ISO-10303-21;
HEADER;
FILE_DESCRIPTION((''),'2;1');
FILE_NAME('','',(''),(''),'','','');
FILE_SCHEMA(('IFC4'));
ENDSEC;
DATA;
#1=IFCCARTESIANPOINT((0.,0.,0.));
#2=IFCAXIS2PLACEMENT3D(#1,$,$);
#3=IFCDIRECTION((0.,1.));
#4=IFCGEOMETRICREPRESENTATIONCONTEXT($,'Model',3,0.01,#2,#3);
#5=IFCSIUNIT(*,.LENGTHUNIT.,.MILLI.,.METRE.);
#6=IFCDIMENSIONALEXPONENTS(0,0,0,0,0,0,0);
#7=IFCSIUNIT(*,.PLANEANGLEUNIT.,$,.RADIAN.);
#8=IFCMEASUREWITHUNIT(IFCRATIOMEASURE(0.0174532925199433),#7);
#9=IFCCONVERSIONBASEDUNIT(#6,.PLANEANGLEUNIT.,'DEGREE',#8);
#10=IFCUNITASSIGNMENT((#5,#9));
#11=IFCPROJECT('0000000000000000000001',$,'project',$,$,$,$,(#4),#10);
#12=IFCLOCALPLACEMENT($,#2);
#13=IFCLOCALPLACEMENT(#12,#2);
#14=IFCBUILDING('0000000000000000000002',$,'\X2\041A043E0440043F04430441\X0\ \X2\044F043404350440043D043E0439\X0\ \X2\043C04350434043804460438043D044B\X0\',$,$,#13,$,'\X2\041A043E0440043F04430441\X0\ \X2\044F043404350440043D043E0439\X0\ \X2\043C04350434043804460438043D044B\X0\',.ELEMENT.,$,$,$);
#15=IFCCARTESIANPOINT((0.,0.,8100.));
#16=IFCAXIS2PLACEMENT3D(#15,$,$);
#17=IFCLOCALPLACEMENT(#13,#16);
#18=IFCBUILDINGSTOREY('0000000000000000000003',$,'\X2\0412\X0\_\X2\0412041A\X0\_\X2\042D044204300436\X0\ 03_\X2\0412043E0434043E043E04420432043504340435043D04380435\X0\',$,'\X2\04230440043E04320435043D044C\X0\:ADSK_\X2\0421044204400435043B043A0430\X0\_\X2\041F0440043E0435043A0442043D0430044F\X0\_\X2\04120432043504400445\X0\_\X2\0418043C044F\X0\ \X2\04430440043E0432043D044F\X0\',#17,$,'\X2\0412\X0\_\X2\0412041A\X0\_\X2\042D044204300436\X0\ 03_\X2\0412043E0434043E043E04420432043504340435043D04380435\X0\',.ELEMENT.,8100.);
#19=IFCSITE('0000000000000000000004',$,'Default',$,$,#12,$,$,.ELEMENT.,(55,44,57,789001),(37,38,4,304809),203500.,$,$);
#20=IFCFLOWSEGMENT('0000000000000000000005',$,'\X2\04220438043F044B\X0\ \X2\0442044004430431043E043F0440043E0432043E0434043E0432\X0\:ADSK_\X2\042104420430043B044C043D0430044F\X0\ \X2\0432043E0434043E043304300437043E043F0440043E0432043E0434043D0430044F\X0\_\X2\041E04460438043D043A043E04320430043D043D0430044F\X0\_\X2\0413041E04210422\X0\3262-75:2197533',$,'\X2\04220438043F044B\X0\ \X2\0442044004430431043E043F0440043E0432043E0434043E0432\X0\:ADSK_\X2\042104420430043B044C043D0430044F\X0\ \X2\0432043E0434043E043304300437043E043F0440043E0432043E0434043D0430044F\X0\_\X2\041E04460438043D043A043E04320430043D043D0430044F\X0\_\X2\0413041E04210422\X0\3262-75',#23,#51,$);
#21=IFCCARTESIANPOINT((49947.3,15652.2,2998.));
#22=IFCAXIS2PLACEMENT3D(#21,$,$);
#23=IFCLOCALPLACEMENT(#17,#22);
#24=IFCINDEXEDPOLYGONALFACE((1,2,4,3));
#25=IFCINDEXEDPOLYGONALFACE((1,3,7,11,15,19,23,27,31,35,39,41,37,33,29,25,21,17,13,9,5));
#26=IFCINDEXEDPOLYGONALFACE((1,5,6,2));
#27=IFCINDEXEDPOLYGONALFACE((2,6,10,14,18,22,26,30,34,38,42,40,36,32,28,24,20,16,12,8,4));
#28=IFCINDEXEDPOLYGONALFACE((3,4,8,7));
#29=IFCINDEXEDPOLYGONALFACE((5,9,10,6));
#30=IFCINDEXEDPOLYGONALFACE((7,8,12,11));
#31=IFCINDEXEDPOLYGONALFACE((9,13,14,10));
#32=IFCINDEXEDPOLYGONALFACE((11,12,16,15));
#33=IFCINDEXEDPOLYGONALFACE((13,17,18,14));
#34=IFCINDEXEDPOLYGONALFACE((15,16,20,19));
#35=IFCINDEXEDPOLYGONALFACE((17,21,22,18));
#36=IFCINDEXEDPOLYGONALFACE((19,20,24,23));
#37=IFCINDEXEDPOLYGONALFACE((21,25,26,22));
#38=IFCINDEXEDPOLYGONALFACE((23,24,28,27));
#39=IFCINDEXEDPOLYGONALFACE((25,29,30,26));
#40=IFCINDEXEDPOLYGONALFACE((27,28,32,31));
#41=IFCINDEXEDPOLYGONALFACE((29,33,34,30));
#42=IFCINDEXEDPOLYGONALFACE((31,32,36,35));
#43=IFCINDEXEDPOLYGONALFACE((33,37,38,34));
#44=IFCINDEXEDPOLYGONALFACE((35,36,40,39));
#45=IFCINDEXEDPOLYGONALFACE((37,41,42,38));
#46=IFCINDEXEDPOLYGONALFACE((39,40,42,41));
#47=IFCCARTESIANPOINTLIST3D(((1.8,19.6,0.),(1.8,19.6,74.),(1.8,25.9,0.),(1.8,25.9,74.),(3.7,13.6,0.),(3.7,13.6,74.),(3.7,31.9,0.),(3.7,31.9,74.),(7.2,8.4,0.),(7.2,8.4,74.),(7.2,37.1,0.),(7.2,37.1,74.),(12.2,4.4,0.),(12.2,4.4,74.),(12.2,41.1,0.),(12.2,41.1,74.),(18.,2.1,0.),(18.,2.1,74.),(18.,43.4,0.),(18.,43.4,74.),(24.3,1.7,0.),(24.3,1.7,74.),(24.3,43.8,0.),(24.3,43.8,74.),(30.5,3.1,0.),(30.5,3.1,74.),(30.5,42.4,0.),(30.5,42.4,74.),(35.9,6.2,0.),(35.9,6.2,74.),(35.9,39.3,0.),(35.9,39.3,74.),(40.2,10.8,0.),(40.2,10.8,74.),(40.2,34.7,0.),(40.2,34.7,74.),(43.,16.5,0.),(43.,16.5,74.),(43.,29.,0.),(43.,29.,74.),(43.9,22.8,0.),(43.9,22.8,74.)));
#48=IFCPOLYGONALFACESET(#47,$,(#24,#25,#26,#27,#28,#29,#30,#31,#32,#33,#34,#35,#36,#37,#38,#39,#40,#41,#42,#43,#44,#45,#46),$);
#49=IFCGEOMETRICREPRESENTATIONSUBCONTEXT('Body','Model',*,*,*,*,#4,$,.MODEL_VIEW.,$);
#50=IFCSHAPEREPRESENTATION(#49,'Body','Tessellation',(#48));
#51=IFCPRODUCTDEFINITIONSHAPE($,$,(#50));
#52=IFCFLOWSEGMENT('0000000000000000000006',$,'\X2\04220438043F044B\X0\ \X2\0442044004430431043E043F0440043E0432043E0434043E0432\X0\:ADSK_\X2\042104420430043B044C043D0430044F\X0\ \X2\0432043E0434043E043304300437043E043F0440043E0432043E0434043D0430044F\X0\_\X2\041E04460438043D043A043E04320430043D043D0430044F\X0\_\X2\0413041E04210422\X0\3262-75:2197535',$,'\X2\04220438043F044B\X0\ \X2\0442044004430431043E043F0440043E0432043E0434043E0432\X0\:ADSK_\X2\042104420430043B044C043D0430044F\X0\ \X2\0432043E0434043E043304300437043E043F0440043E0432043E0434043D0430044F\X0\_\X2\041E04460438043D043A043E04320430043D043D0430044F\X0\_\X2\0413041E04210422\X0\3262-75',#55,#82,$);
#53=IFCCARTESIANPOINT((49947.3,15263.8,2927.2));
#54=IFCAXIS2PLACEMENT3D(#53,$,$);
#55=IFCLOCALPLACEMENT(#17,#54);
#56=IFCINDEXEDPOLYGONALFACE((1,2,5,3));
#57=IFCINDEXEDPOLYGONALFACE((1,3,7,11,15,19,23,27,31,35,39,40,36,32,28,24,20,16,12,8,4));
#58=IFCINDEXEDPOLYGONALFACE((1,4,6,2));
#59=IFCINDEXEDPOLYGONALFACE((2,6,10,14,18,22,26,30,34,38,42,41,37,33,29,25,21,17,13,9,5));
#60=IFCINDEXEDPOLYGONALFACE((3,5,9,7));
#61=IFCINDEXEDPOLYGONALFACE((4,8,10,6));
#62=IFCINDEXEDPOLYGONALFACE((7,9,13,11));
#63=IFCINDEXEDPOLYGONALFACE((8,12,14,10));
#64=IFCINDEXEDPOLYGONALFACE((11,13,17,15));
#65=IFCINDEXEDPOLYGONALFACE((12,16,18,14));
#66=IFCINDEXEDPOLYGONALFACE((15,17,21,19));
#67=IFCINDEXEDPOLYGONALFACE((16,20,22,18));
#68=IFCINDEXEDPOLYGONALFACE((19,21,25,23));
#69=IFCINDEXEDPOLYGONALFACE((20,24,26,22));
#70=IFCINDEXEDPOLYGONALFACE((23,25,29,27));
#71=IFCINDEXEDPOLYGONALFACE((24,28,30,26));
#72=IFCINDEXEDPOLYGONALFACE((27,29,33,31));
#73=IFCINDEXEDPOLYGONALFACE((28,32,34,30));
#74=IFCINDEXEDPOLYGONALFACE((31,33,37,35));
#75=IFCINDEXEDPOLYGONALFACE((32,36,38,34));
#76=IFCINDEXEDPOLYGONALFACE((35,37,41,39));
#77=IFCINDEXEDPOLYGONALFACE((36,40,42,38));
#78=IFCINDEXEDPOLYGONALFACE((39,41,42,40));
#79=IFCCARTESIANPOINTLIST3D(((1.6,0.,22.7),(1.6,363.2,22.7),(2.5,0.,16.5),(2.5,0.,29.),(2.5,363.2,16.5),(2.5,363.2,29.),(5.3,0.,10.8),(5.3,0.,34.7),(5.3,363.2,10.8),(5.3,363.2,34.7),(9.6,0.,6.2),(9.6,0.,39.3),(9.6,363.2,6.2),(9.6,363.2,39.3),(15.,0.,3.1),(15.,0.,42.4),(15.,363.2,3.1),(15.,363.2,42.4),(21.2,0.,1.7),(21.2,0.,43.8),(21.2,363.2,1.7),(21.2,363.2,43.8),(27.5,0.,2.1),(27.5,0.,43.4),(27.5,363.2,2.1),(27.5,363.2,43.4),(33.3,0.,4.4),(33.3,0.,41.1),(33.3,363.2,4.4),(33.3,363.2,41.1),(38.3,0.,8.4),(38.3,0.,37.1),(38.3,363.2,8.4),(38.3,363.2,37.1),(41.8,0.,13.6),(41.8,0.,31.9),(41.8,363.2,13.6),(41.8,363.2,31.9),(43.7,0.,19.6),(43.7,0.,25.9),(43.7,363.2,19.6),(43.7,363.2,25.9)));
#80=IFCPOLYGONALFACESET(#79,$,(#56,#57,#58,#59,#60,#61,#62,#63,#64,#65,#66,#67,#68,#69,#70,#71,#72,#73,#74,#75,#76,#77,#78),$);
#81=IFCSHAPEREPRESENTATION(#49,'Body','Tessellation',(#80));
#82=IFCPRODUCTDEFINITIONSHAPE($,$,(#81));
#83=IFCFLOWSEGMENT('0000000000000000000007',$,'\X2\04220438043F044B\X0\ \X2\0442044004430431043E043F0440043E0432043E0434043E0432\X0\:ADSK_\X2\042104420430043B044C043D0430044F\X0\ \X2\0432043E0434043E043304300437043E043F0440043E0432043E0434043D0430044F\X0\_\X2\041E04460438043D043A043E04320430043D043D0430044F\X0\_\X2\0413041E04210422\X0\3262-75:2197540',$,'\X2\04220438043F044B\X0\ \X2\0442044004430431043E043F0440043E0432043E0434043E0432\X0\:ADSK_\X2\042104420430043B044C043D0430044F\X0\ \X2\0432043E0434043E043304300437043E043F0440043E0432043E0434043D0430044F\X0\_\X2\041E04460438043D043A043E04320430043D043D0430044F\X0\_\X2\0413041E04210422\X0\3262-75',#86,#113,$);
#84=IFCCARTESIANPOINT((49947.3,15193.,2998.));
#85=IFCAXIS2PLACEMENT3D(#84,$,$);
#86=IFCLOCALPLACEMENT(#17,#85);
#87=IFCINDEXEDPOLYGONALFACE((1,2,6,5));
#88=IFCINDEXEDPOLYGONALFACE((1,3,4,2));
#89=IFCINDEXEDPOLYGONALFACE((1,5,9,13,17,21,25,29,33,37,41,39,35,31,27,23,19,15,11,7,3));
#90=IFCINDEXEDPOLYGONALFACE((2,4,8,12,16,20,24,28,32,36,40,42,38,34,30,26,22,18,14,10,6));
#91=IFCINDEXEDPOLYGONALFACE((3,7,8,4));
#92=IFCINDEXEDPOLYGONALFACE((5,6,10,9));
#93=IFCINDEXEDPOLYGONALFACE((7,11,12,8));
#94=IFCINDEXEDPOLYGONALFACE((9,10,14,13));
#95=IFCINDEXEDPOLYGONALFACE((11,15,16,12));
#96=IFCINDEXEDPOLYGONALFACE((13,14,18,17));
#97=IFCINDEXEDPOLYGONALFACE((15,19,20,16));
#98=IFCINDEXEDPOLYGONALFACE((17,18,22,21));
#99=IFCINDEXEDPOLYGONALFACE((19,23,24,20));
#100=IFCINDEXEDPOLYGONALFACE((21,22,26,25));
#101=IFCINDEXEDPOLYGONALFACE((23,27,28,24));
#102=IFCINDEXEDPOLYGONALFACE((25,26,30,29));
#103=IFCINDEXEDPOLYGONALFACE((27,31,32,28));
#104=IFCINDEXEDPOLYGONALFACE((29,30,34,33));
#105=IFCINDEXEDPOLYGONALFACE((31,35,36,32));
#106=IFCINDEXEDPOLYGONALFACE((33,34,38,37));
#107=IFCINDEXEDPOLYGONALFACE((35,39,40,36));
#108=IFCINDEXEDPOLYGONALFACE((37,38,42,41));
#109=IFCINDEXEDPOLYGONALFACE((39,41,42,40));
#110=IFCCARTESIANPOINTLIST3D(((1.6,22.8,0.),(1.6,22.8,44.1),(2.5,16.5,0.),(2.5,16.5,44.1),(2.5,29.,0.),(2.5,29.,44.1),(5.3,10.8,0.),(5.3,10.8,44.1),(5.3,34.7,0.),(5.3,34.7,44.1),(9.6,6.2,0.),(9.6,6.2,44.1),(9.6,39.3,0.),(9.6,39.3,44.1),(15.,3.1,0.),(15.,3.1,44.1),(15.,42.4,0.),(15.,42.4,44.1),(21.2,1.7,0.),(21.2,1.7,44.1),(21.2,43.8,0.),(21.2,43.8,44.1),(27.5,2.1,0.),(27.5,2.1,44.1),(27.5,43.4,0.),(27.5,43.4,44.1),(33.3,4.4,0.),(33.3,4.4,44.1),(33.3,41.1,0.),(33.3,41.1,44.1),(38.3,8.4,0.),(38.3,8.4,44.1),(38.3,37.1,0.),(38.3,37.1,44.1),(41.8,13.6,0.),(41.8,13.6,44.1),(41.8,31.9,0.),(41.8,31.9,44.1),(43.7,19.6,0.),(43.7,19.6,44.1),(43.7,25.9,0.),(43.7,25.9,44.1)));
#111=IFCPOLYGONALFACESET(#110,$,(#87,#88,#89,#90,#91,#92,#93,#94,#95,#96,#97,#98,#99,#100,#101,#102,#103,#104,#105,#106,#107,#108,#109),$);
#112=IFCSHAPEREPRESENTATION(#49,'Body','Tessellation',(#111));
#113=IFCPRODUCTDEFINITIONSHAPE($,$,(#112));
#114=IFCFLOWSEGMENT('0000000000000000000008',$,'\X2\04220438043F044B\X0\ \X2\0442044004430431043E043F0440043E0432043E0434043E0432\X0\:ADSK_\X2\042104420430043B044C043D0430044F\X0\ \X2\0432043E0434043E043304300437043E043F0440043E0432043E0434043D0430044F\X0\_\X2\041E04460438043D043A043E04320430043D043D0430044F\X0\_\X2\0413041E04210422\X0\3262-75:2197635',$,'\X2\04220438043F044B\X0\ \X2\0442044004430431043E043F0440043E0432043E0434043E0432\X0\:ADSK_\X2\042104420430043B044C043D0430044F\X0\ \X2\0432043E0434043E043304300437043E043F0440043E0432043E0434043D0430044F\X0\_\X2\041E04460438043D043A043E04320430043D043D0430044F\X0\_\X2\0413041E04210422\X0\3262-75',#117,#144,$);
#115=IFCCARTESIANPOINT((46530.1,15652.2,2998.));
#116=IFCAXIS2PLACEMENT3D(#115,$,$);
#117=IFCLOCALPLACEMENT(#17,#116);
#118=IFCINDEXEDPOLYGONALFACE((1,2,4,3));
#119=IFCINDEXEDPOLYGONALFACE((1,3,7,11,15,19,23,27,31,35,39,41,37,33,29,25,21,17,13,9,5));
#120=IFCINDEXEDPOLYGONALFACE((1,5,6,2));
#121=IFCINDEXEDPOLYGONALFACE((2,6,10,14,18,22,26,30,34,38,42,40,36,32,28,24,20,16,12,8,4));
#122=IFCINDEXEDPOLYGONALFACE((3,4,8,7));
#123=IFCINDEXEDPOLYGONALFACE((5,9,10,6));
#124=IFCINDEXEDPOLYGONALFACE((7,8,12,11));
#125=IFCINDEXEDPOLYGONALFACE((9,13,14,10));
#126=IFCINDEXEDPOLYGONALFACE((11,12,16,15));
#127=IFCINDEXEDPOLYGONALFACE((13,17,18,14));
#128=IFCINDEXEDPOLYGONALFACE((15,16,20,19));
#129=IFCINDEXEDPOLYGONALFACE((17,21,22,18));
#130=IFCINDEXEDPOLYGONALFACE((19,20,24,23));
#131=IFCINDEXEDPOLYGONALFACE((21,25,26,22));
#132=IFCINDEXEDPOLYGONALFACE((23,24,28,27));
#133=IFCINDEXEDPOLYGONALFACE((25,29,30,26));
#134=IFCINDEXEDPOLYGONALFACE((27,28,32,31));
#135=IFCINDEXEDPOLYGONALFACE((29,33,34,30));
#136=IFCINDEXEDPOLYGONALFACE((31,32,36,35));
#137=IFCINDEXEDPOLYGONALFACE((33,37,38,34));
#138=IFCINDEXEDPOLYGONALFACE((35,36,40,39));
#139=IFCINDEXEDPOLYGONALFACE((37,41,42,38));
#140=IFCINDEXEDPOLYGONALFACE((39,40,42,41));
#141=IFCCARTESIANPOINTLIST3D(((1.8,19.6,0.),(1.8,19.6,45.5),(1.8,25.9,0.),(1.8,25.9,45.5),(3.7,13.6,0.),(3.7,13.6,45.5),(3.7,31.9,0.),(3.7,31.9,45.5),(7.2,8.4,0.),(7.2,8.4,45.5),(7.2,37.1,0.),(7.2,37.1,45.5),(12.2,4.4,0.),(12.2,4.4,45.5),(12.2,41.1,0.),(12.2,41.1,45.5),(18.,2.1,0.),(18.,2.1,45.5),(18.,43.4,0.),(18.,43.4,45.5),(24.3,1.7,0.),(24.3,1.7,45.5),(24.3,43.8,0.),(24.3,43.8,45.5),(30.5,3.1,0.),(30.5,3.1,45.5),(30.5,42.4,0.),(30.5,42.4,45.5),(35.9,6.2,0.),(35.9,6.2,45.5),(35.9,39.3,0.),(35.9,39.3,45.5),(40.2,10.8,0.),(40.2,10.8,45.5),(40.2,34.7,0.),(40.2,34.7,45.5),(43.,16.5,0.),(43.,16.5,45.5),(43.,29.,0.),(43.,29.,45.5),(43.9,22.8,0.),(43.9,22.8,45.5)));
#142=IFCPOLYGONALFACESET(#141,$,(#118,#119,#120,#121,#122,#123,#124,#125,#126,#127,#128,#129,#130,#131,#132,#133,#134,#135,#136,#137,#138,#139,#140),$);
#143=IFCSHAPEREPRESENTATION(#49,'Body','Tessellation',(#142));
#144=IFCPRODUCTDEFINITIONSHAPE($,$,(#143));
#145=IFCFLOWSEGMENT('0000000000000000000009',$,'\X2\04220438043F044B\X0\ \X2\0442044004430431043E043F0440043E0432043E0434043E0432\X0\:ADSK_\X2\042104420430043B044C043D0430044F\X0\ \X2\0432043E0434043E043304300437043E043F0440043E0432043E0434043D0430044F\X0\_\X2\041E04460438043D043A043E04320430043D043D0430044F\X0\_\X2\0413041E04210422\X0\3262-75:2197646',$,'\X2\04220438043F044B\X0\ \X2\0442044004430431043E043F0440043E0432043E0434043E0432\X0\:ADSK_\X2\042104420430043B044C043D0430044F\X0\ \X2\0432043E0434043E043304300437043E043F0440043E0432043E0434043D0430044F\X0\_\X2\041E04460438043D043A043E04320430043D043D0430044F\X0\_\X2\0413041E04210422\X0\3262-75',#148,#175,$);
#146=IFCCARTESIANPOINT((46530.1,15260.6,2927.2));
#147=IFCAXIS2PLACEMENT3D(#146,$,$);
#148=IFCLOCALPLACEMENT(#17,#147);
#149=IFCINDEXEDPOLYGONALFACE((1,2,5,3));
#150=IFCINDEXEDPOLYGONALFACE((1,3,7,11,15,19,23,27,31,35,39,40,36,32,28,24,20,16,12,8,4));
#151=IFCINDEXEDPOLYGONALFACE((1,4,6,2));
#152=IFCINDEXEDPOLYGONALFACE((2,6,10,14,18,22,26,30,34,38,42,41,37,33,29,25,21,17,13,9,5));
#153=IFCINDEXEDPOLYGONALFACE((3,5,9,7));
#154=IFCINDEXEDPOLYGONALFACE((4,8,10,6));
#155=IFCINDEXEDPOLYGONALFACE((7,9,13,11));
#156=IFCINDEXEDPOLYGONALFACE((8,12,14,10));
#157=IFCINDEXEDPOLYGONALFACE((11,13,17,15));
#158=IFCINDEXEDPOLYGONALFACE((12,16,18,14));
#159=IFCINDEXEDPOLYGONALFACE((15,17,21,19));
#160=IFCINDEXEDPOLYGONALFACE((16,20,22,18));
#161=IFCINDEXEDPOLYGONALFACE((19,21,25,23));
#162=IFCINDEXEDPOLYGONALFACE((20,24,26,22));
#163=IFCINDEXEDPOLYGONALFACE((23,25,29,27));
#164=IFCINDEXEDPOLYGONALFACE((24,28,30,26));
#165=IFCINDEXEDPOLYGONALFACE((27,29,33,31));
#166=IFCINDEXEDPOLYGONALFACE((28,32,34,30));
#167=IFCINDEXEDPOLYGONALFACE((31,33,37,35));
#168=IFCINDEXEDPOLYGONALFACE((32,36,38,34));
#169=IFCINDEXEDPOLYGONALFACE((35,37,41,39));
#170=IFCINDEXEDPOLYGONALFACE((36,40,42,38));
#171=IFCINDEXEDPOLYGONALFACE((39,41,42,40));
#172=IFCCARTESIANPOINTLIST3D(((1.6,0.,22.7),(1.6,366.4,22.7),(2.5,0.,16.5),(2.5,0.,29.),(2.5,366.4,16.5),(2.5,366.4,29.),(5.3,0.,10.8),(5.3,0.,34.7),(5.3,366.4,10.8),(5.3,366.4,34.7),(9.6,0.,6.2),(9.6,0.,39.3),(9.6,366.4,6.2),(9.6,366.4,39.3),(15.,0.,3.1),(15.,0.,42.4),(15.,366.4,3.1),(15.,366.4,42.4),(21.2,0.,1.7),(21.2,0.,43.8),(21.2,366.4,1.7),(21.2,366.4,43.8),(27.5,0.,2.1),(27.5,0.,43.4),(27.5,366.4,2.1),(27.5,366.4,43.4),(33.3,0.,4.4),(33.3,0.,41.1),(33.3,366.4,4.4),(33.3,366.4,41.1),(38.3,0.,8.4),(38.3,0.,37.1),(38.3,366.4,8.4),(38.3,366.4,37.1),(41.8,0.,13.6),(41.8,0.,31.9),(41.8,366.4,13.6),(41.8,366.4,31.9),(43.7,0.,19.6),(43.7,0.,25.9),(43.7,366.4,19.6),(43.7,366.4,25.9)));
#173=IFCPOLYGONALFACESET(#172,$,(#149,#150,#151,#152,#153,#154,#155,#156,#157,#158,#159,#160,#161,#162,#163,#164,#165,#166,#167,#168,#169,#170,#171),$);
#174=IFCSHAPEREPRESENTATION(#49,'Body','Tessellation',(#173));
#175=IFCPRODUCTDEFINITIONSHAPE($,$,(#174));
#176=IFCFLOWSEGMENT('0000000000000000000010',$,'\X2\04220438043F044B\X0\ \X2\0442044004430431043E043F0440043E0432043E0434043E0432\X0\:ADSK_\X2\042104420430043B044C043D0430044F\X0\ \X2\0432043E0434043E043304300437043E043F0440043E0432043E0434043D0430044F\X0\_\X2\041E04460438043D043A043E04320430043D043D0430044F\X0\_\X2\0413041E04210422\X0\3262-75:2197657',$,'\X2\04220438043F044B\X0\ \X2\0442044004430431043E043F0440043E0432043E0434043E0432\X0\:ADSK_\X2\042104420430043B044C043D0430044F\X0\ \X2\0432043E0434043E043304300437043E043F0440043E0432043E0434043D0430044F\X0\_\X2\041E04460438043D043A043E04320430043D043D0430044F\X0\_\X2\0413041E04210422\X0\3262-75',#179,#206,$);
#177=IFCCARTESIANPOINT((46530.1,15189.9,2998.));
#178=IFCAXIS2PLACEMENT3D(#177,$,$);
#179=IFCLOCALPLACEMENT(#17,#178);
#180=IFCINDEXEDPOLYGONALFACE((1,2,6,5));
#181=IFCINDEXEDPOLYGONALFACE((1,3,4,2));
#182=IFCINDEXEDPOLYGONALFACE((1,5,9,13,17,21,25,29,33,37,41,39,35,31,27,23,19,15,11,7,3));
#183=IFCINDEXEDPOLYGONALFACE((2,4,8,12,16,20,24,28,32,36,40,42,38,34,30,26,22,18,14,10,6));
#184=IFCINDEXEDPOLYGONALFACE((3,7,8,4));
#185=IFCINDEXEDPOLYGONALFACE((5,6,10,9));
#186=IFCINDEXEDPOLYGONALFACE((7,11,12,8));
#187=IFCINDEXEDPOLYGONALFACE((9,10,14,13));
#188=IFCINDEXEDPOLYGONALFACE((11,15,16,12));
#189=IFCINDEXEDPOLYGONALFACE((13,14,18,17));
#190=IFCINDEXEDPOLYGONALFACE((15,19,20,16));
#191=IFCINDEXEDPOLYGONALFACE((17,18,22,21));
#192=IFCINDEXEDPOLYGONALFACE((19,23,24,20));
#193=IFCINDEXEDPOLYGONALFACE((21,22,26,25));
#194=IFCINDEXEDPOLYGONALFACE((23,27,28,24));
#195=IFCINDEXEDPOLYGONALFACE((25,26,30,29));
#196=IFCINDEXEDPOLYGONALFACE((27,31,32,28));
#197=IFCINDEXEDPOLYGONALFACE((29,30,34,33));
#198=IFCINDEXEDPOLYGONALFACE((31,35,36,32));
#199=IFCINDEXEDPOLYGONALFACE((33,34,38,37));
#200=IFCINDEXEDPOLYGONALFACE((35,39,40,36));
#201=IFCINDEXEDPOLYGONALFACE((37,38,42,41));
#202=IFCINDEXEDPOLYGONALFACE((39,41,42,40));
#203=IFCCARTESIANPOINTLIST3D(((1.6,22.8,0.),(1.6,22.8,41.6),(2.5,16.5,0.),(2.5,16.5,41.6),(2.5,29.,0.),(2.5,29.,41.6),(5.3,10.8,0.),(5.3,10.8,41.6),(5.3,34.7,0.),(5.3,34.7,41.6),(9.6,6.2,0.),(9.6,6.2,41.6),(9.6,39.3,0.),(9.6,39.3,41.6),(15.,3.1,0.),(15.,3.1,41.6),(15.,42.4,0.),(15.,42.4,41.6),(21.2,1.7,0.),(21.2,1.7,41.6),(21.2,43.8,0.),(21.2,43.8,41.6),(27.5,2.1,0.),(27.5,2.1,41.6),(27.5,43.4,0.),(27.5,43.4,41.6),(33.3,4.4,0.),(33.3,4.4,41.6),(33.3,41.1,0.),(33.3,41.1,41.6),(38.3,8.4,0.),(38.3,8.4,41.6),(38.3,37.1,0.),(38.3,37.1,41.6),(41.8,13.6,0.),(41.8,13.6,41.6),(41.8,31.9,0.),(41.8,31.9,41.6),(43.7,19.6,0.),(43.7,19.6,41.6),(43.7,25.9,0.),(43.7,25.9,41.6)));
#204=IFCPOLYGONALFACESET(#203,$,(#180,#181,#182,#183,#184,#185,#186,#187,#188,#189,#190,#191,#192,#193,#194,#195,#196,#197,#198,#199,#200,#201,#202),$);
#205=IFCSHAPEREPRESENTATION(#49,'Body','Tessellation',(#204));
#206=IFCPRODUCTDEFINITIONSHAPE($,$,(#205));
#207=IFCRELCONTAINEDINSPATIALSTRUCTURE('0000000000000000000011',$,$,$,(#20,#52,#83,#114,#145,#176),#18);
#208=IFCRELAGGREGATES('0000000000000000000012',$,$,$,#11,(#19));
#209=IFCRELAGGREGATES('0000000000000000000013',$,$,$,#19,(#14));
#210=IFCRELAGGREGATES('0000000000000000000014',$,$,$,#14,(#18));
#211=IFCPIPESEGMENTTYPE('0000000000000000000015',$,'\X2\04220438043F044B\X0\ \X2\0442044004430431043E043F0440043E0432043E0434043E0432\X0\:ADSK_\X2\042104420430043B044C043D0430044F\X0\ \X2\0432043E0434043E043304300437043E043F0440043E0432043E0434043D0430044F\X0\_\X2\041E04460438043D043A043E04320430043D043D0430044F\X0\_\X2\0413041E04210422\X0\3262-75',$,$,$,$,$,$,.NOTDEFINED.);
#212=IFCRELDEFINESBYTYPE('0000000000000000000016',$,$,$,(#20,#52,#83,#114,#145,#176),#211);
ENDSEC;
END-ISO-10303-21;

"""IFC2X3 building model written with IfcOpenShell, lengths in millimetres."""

from ifc_helpers import new_model, entity, si_unit, converted_unit, direction, frame, origin, origin_2d_with_axis, place, context, subcontext, project, spatial, circle, extrude, type_object, element, save


model = new_model("IFC2X3")

# Units and contexts
model_context = context("Model", 3, precision=0.01, world=origin(), true_north=direction((0.0, 1.0)))
body_context = subcontext(model_context, "Body", "Model", "MODEL_VIEW")
ifc_project = project(units=[si_unit("LENGTHUNIT", "METRE", prefix="MILLI"), converted_unit("PLANEANGLEUNIT", "DEGREE", entity("IfcRatioMeasure", 0.0174532925199433), si_unit("PLANEANGLEUNIT", "RADIAN"), dimensions=[0, 0, 0, 0, 0, 0, 0])], contexts=[model_context])

# Site, building, storey
site_placement = place(None, origin())
site = spatial("IfcSite", under=ifc_project, at=site_placement, Name="Default", CompositionType="ELEMENT", RefLatitude=(55, 44, 57, 789001), RefLongitude=(37, 38, 4, 304809), RefElevation=203500.0)
building_placement = place(site_placement, origin())
building = spatial("IfcBuilding", under=site, at=building_placement, Name="Корпус ядерной медицины", LongName="Корпус ядерной медицины", CompositionType="ELEMENT")
storey_placement = place(building_placement, frame((0.0, 0.0, 8100.0)))
storey = spatial("IfcBuildingStorey", under=building, at=storey_placement, Name="В_ВК_Этаж 03_Водоотведение", ObjectType="Уровень:ADSK_Стрелка_Проектная_Вверх_Имя уровня", LongName="В_ВК_Этаж 03_Водоотведение", CompositionType="ELEMENT", Elevation=8100.0)

# Flow segments
pipe_segment_type_1 = type_object("IfcPipeSegmentType", Name="Типы трубопроводов:ADSK_Стальная водогазопроводная_Оцинкованная_ГОСТ3262-75", PredefinedType="NOTDEFINED")
flow_segment_1_placement = place(storey_placement, frame((49947.3, 15652.2, 2998.0)))
element("IfcFlowSegment", 1, at=flow_segment_1_placement, inside=storey, type_object=pipe_segment_type_1, Name="Типы трубопроводов:ADSK_Стальная водогазопроводная_Оцинкованная_ГОСТ3262-75:2197533", ObjectType="Типы трубопроводов:ADSK_Стальная водогазопроводная_Оцинкованная_ГОСТ3262-75", context=body_context, shape_type="SweptSolid", body=[
    extrude(circle(Radius=21.1, at=origin_2d_with_axis()), frame((22.8, 22.8, 0.0)), (0.0, 0.0, 1.0), 74.0),
])
flow_segment_2_placement = place(storey_placement, frame((49947.3, 15263.8, 2927.2)))
element("IfcFlowSegment", 2, at=flow_segment_2_placement, inside=storey, type_object=pipe_segment_type_1, Name="Типы трубопроводов:ADSK_Стальная водогазопроводная_Оцинкованная_ГОСТ3262-75:2197535", ObjectType="Типы трубопроводов:ADSK_Стальная водогазопроводная_Оцинкованная_ГОСТ3262-75", context=body_context, shape_type="SweptSolid", body=[
    extrude(circle(Radius=21.1, at=origin_2d_with_axis()), frame((22.8, 0.0, 22.8), z_axis=(0.0, 1.0, 0.0), x_axis=(-1.0, 0.0, 0.0)), (0.0, 0.0, 1.0), 363.2),
])
flow_segment_3_placement = place(storey_placement, frame((49947.3, 15193.0, 2998.0)))
element("IfcFlowSegment", 3, at=flow_segment_3_placement, inside=storey, type_object=pipe_segment_type_1, Name="Типы трубопроводов:ADSK_Стальная водогазопроводная_Оцинкованная_ГОСТ3262-75:2197540", ObjectType="Типы трубопроводов:ADSK_Стальная водогазопроводная_Оцинкованная_ГОСТ3262-75", context=body_context, shape_type="SweptSolid", body=[
    extrude(circle(Radius=21.1, at=origin_2d_with_axis()), frame((22.8, 22.8, 0.0), z_axis=(0.0, 0.0, 1.0), x_axis=(-1.0, 0.0, 0.0)), (0.0, 0.0, 1.0), 44.1),
])
flow_segment_4_placement = place(storey_placement, frame((46530.1, 15652.2, 2998.0)))
element("IfcFlowSegment", 4, at=flow_segment_4_placement, inside=storey, type_object=pipe_segment_type_1, Name="Типы трубопроводов:ADSK_Стальная водогазопроводная_Оцинкованная_ГОСТ3262-75:2197635", ObjectType="Типы трубопроводов:ADSK_Стальная водогазопроводная_Оцинкованная_ГОСТ3262-75", context=body_context, shape_type="SweptSolid", body=[
    extrude(circle(Radius=21.1, at=origin_2d_with_axis()), frame((22.8, 22.8, 0.0)), (0.0, 0.0, 1.0), 45.5),
])
flow_segment_5_placement = place(storey_placement, frame((46530.1, 15260.6, 2927.2)))
element("IfcFlowSegment", 5, at=flow_segment_5_placement, inside=storey, type_object=pipe_segment_type_1, Name="Типы трубопроводов:ADSK_Стальная водогазопроводная_Оцинкованная_ГОСТ3262-75:2197646", ObjectType="Типы трубопроводов:ADSK_Стальная водогазопроводная_Оцинкованная_ГОСТ3262-75", context=body_context, shape_type="SweptSolid", body=[
    extrude(circle(Radius=21.1, at=origin_2d_with_axis()), frame((22.8, 0.0, 22.8), z_axis=(0.0, 1.0, 0.0), x_axis=(-1.0, 0.0, 0.0)), (0.0, 0.0, 1.0), 366.4),
])
flow_segment_6_placement = place(storey_placement, frame((46530.1, 15189.9, 2998.0)))
element("IfcFlowSegment", 6, at=flow_segment_6_placement, inside=storey, type_object=pipe_segment_type_1, Name="Типы трубопроводов:ADSK_Стальная водогазопроводная_Оцинкованная_ГОСТ3262-75:2197657", ObjectType="Типы трубопроводов:ADSK_Стальная водогазопроводная_Оцинкованная_ГОСТ3262-75", context=body_context, shape_type="SweptSolid", body=[
    extrude(circle(Radius=21.1, at=origin_2d_with_axis()), frame((22.8, 22.8, 0.0), z_axis=(0.0, 0.0, 1.0), x_axis=(-1.0, 0.0, 0.0)), (0.0, 0.0, 1.0), 41.6),
])

save(model, "model.ifc")
